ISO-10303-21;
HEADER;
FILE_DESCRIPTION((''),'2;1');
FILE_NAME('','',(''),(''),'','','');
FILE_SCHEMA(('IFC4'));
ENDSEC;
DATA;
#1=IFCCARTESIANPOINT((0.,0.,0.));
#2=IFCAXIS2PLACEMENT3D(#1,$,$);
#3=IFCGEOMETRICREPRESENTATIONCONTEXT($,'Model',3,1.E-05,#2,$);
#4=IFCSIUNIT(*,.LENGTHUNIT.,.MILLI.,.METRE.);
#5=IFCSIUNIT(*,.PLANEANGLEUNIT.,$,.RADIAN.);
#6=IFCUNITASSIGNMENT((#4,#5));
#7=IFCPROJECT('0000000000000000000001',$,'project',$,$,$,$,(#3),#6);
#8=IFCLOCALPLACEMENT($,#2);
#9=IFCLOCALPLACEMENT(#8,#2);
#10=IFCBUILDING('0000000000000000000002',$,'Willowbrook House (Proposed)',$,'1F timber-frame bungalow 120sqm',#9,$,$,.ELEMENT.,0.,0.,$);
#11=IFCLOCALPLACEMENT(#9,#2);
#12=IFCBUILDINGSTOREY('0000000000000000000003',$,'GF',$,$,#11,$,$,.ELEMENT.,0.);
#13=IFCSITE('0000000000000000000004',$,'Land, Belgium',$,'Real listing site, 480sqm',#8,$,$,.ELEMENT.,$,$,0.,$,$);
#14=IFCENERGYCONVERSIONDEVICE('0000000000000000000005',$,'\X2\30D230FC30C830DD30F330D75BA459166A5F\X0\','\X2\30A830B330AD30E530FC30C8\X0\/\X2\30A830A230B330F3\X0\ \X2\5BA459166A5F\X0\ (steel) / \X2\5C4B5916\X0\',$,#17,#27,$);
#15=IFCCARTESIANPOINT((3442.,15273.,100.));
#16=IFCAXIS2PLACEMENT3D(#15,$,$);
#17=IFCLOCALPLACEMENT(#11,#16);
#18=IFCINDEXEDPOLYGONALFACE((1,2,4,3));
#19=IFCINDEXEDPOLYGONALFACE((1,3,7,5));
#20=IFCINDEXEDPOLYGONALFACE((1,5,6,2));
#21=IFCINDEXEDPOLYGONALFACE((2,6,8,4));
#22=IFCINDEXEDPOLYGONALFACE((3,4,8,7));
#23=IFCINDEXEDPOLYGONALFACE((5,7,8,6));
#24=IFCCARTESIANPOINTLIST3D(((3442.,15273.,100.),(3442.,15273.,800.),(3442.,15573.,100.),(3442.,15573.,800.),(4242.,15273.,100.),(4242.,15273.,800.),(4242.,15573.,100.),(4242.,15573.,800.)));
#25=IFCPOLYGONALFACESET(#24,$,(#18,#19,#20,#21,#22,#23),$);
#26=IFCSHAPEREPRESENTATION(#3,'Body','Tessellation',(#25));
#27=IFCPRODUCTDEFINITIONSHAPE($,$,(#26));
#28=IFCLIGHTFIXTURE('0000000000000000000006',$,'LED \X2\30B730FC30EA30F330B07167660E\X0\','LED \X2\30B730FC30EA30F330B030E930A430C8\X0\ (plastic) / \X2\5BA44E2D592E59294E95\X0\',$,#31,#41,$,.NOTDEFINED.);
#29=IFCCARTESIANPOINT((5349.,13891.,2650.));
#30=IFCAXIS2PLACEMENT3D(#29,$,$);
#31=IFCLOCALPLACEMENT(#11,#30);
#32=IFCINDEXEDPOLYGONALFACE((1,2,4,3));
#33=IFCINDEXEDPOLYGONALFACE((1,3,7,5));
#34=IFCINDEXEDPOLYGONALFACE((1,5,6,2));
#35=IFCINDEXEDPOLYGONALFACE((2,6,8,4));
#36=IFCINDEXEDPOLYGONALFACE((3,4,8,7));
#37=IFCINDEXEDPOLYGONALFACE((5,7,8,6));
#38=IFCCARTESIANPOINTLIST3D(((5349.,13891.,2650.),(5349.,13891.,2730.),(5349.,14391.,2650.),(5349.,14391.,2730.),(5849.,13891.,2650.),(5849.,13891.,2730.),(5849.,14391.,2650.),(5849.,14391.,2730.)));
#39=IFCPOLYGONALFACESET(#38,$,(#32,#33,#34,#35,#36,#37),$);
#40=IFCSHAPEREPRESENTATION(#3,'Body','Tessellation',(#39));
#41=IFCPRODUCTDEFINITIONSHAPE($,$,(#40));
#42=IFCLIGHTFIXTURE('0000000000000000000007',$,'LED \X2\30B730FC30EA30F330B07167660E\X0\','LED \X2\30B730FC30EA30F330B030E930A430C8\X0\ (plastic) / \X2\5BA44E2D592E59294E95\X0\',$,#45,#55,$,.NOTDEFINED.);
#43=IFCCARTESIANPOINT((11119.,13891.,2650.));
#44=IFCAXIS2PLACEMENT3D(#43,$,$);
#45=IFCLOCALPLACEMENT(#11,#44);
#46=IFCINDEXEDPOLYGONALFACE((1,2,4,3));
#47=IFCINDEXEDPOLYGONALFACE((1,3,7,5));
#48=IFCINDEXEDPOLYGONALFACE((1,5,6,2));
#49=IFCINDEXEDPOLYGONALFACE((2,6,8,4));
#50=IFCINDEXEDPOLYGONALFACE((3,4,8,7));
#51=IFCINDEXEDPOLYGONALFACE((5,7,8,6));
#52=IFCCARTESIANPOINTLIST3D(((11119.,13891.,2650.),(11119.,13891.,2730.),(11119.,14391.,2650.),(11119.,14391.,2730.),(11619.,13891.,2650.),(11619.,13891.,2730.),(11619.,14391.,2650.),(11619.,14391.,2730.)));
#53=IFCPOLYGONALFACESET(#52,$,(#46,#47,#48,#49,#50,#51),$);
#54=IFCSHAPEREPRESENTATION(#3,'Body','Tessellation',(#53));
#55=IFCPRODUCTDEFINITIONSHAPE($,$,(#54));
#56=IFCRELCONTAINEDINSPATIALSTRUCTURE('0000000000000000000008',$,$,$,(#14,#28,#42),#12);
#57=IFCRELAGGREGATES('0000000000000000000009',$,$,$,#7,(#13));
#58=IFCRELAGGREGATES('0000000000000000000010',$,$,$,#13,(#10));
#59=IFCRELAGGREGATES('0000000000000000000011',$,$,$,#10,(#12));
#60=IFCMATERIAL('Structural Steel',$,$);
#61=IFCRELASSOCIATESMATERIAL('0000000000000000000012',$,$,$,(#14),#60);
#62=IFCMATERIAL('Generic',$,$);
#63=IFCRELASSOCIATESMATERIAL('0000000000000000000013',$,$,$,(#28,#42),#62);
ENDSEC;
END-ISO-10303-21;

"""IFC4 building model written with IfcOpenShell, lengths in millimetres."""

from ifc_helpers import new_model, si_unit, frame, frame_2d, origin, place, context, project, spatial, rectangle, extrude, material, element, save


model = new_model("IFC4")

# Units and contexts
model_context = context("Model", 3, precision=1e-05, world=origin())
ifc_project = project(units=[si_unit("LENGTHUNIT", "METRE", prefix="MILLI"), si_unit("PLANEANGLEUNIT", "RADIAN")], contexts=[model_context])

# Site, building, storey
site_placement = place(None, origin())
site = spatial("IfcSite", under=ifc_project, at=site_placement, Name="Land, Belgium", ObjectType="Real listing site, 480sqm", CompositionType="ELEMENT", RefElevation=0.0)
building_placement = place(site_placement, origin())
building = spatial("IfcBuilding", under=site, at=building_placement, Name="Willowbrook House (Proposed)", ObjectType="1F timber-frame bungalow 120sqm", CompositionType="ELEMENT", ElevationOfRefHeight=0.0, ElevationOfTerrain=0.0)
storey_placement = place(building_placement, origin())
storey = spatial("IfcBuildingStorey", under=building, at=storey_placement, Name="GF", CompositionType="ELEMENT", Elevation=0.0)

# Shared definitions
ifc_material_1 = material(Name="Structural Steel")

# Shared definitions
ifc_material_2 = material(Name="Generic")

# Energy conversion device
energy_conversion_device_placement = place(storey_placement, frame((3442.0, 15273.0, 100.0)))
element("IfcEnergyConversionDevice", 1, at=energy_conversion_device_placement, inside=storey, material=ifc_material_1, Name="ヒートポンプ室外機", Description="エコキュート/エアコン 室外機 (steel) / 屋外", context=model_context, shape_type="SweptSolid", body=[
    extrude(rectangle(XDim=800.0, YDim=300.0, at=frame_2d((400.0, 150.0))), frame((3442.0, 15273.0, 100.0)), (0.0, 0.0, 1.0), 700.0),
])

# Light fixtures
light_fixture_1_placement = place(storey_placement, frame((5349.0, 13891.0, 2650.0)))
element("IfcLightFixture", 2, at=light_fixture_1_placement, inside=storey, material=ifc_material_2, Name="LED シーリング照明", Description="LED シーリングライト (plastic) / 室中央天井", PredefinedType="NOTDEFINED", context=model_context, shape_type="SweptSolid", body=[
    extrude(rectangle(XDim=500.0, YDim=500.0, at=frame_2d((250.0, 250.0))), frame((5349.0, 13891.0, 2650.0)), (0.0, 0.0, 1.0), 80.0),
])
light_fixture_2_placement = place(storey_placement, frame((11119.0, 13891.0, 2650.0)))
element("IfcLightFixture", 3, at=light_fixture_2_placement, inside=storey, material=ifc_material_2, Name="LED シーリング照明", Description="LED シーリングライト (plastic) / 室中央天井", PredefinedType="NOTDEFINED", context=model_context, shape_type="SweptSolid", body=[
    extrude(rectangle(XDim=500.0, YDim=500.0, at=frame_2d((250.0, 250.0))), frame((11119.0, 13891.0, 2650.0)), (0.0, 0.0, 1.0), 80.0),
])

save(model, "model.ifc")
